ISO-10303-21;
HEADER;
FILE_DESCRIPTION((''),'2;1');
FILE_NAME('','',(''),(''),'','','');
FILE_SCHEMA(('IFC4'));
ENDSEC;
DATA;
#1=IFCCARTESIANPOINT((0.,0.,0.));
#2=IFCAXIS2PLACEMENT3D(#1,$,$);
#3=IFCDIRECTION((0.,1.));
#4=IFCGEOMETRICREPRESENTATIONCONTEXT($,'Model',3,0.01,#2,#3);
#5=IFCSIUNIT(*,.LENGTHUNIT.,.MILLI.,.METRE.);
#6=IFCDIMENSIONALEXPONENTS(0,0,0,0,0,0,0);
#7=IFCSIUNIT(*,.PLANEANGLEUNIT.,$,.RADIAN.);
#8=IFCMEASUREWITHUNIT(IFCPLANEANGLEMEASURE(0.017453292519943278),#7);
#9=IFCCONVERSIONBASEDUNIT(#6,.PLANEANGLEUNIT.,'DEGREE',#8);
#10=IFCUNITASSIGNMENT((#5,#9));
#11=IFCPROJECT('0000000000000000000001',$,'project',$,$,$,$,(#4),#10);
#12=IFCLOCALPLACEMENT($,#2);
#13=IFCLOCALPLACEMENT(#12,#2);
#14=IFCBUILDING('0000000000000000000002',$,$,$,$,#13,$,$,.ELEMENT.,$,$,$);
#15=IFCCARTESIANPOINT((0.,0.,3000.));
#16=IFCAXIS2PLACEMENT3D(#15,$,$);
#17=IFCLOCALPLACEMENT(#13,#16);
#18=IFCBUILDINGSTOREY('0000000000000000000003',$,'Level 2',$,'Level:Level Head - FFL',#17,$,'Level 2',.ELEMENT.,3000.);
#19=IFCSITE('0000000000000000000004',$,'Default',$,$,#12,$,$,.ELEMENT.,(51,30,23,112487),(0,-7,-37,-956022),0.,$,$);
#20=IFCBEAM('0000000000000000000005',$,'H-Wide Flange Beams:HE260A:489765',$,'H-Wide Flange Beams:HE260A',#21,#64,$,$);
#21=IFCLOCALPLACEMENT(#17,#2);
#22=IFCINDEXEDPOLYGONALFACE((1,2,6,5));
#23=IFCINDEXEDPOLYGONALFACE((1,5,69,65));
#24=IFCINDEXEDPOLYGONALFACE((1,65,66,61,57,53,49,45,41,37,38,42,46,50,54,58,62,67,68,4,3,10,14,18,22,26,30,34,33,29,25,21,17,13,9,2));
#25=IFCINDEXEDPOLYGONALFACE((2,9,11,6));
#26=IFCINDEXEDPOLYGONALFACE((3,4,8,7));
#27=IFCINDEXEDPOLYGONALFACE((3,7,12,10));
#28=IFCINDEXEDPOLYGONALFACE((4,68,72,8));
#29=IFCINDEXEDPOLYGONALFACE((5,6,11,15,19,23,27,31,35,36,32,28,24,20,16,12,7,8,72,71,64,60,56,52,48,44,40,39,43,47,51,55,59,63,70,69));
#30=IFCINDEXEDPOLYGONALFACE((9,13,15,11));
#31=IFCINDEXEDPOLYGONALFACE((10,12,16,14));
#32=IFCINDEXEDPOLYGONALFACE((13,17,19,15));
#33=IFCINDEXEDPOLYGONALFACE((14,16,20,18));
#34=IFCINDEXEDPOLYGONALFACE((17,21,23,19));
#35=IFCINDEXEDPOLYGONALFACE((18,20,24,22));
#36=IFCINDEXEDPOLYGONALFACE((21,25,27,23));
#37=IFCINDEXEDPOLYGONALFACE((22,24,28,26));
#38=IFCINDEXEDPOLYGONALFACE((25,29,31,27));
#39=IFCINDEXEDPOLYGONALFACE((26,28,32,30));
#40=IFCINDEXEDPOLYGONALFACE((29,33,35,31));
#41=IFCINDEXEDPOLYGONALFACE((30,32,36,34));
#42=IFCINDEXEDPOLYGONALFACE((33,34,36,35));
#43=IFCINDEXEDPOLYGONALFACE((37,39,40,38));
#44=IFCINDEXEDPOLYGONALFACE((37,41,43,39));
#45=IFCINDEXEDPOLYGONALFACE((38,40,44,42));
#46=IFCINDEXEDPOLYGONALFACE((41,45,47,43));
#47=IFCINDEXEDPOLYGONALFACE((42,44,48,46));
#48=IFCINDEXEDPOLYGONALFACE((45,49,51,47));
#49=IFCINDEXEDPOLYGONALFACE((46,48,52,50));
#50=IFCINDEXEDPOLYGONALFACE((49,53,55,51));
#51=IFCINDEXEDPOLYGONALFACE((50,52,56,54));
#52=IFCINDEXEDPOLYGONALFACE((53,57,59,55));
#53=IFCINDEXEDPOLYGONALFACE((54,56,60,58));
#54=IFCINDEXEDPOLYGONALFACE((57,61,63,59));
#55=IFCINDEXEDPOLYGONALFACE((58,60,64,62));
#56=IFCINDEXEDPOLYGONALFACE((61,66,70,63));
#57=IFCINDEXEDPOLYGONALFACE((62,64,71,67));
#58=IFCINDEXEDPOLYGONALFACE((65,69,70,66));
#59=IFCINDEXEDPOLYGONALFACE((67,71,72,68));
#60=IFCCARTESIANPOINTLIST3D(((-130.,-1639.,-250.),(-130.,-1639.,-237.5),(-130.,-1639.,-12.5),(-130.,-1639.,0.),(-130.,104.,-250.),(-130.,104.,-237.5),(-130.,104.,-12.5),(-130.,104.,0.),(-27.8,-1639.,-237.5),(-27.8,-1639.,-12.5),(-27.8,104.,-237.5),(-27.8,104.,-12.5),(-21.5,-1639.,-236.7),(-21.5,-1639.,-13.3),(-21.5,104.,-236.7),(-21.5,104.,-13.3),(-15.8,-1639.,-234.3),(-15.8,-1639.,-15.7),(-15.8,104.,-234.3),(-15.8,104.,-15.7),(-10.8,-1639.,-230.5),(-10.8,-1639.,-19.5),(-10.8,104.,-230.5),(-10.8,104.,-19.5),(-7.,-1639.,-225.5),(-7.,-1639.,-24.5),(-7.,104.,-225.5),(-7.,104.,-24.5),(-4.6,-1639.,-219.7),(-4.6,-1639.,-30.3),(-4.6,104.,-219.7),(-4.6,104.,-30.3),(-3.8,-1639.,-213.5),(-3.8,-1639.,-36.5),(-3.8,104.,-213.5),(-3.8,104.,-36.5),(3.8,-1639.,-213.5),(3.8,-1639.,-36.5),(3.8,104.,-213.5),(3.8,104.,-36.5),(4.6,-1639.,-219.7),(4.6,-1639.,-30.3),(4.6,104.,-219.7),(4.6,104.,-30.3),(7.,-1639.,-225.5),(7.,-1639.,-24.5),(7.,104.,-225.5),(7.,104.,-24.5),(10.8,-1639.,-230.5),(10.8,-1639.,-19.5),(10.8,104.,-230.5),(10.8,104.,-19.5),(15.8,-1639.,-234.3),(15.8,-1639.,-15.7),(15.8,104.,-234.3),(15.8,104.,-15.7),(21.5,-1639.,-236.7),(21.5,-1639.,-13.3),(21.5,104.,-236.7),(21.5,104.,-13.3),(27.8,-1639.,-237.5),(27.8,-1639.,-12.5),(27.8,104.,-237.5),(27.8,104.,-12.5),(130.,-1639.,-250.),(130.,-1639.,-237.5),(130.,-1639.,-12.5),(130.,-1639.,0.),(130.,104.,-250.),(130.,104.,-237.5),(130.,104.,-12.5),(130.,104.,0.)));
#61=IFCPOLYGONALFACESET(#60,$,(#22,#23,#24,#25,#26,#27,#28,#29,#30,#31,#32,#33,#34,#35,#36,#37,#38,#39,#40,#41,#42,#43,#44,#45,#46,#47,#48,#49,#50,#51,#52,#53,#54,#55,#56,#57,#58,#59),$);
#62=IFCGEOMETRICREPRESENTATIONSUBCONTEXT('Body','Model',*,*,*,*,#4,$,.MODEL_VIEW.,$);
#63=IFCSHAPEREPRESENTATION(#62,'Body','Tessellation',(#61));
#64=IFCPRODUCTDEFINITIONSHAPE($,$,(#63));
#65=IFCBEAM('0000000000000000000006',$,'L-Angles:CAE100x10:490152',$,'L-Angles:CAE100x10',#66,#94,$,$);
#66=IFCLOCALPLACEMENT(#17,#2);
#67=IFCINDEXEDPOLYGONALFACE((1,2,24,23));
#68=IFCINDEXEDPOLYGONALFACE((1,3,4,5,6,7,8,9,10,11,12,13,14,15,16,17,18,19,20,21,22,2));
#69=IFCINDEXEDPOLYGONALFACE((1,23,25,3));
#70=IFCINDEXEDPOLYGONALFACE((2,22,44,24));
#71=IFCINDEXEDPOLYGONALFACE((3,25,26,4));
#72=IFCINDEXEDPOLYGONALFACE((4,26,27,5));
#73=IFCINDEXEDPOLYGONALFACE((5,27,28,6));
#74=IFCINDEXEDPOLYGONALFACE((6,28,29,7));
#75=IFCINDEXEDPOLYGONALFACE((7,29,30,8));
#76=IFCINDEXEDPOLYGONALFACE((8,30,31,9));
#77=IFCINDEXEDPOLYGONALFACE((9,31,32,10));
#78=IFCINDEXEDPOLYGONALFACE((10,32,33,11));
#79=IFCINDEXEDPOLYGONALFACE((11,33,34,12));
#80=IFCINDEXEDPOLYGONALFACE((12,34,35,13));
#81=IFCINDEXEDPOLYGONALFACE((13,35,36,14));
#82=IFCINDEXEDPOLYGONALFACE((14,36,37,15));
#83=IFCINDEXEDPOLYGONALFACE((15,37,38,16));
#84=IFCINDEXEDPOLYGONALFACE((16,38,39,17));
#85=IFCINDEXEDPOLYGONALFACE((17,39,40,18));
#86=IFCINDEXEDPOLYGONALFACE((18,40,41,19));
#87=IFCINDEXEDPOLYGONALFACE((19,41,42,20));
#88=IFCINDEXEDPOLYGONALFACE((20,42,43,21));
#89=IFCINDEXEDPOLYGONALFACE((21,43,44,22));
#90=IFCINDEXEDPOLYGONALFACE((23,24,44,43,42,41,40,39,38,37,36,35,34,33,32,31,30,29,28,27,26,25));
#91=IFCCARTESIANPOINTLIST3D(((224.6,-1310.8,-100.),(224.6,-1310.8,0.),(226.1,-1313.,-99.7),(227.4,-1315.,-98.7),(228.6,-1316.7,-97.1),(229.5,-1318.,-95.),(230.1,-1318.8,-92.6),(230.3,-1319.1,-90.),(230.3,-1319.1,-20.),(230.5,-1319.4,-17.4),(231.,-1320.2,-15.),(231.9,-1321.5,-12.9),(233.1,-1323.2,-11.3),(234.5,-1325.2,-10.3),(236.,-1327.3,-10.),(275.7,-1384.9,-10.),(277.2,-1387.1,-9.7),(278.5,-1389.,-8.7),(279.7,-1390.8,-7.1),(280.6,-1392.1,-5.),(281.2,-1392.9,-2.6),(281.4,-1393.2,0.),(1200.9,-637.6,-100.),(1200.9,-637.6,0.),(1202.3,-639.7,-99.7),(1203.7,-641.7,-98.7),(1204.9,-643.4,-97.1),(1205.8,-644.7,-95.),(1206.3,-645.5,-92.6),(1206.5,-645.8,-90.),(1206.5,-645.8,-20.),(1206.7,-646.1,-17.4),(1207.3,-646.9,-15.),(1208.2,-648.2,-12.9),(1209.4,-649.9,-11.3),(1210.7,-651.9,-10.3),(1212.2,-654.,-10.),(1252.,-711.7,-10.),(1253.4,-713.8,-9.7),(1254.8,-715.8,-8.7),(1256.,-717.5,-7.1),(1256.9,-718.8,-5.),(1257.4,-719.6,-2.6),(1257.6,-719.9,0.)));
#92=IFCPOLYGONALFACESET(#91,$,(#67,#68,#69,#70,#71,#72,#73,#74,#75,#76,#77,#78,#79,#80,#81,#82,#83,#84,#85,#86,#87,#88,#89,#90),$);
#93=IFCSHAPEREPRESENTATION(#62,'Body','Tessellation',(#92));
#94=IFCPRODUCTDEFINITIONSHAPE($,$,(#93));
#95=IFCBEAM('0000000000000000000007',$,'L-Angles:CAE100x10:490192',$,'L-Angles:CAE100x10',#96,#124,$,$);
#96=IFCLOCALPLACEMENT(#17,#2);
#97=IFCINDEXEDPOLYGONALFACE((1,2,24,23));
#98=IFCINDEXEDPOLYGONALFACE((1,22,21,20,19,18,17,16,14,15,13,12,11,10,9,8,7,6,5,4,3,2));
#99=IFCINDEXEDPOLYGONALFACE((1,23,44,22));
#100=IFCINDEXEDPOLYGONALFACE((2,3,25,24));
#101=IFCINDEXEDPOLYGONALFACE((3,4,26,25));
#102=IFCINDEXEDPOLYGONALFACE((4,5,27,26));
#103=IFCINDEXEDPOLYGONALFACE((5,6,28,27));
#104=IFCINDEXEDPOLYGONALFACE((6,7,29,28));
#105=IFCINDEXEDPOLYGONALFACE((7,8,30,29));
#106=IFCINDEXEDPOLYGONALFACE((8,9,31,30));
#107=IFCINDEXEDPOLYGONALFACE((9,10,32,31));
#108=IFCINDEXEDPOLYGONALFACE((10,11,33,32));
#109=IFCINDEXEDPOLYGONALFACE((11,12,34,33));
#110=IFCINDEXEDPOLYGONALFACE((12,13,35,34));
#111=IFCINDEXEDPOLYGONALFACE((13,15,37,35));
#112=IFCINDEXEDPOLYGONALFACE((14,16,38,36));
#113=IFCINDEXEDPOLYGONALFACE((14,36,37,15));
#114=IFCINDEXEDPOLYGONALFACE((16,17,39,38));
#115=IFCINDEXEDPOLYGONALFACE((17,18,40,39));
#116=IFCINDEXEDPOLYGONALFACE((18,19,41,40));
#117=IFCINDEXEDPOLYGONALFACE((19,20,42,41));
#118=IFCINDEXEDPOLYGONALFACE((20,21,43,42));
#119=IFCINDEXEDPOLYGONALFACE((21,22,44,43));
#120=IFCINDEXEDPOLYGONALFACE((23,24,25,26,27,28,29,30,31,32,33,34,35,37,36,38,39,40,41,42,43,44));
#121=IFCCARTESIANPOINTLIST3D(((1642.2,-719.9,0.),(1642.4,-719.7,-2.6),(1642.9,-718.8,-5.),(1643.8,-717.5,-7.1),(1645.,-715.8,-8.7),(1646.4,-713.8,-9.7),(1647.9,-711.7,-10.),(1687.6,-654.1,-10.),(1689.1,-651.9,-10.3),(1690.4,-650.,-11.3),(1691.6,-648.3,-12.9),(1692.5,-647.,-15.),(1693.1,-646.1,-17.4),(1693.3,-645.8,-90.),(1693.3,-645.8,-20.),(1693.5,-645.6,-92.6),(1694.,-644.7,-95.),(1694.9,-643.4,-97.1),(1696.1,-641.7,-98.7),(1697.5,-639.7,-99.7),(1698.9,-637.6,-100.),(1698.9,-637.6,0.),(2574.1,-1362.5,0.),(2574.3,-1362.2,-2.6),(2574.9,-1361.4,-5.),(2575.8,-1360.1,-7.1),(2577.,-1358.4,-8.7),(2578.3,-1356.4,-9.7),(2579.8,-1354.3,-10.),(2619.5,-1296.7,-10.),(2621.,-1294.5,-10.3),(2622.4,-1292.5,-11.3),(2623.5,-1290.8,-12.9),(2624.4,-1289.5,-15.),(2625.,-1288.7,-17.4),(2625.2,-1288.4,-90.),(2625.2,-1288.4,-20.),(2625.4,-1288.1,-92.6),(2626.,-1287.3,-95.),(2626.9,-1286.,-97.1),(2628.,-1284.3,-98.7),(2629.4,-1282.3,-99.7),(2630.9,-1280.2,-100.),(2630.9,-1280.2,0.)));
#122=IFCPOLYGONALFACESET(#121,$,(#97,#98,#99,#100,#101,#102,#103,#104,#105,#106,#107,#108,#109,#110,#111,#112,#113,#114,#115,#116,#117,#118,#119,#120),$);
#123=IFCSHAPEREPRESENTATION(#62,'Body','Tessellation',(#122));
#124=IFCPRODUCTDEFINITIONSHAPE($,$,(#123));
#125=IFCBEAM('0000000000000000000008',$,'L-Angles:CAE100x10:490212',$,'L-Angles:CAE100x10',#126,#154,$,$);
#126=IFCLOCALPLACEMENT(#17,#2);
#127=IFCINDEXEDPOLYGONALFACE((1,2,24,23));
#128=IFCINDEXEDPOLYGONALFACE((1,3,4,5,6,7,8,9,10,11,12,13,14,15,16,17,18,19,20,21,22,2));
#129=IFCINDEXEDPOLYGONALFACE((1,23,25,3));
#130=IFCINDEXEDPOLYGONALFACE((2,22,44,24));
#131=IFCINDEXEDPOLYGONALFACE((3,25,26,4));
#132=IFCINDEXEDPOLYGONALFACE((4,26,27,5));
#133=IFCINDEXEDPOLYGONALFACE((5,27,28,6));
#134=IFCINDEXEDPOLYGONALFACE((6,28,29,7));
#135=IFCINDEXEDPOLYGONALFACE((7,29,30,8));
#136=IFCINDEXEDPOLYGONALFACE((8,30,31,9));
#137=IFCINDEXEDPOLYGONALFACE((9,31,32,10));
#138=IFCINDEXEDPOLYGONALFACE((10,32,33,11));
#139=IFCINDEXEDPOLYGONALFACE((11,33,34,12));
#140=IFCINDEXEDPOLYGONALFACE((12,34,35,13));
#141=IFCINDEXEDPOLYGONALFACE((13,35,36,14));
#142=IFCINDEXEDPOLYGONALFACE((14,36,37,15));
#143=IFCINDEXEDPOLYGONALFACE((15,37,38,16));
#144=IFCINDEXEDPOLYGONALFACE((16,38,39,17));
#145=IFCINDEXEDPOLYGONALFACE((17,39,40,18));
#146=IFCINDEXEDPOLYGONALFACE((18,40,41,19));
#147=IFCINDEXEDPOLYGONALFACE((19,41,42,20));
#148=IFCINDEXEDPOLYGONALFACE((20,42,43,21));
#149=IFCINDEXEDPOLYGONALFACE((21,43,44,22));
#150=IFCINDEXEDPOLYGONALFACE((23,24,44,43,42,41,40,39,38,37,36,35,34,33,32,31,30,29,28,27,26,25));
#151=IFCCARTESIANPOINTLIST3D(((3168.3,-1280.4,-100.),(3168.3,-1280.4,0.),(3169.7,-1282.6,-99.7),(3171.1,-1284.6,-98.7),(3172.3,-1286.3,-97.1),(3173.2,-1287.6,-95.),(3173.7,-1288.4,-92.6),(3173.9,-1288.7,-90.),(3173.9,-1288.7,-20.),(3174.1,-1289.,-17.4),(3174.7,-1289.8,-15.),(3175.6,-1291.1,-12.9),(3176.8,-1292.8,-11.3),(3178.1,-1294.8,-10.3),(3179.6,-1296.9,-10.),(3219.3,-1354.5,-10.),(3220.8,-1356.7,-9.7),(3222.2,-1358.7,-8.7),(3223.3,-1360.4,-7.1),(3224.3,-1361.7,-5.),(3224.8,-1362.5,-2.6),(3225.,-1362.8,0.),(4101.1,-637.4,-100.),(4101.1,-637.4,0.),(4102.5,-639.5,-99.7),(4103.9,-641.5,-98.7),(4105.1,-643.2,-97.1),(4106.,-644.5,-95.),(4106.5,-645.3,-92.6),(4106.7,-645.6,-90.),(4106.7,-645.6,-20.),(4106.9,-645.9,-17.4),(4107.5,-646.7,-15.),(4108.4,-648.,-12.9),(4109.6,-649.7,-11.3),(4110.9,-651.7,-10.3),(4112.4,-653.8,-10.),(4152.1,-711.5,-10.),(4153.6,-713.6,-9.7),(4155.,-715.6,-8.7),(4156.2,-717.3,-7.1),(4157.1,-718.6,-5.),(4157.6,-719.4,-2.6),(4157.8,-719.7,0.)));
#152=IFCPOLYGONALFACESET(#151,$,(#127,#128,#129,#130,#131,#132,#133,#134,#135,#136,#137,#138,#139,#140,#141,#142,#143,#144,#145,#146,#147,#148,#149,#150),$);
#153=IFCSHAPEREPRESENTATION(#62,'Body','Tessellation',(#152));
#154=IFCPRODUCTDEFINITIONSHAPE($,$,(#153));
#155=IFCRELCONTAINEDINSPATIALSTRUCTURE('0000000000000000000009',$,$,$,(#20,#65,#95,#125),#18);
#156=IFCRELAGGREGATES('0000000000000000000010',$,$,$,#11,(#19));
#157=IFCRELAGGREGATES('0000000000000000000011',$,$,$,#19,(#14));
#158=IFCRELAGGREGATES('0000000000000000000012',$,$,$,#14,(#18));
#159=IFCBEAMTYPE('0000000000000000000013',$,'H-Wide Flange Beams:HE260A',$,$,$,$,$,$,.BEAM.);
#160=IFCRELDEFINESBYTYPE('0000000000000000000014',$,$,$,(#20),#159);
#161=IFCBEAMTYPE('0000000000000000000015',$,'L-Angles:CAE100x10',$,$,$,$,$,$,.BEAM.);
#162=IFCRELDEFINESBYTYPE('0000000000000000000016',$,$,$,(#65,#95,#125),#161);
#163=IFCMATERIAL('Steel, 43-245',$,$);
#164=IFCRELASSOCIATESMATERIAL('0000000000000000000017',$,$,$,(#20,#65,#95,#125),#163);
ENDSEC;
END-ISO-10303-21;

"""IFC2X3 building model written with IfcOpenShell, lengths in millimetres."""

from ifc_helpers import new_model, entity, si_unit, converted_unit, direction, frame, frame_2d, origin, place, context, subcontext, project, spatial, polyline, circle_curve, parameter, trimmed, segment, composite_curve, i_section, outline, extrude, material, type_object, element, save


model = new_model("IFC2X3")

# Units and contexts
model_context = context("Model", 3, precision=0.01, world=origin(), true_north=direction((0.0, 1.0)))
body_context = subcontext(model_context, "Body", "Model", "MODEL_VIEW")
ifc_project = project(units=[si_unit("LENGTHUNIT", "METRE", prefix="MILLI"), converted_unit("PLANEANGLEUNIT", "DEGREE", entity("IfcPlaneAngleMeasure", 0.017453292519943278), si_unit("PLANEANGLEUNIT", "RADIAN"), dimensions=[0, 0, 0, 0, 0, 0, 0])], contexts=[model_context])

# Site, building, storey
site_placement = place(None, origin())
site = spatial("IfcSite", under=ifc_project, at=site_placement, Name="Default", CompositionType="ELEMENT", RefLatitude=(51, 30, 23, 112487), RefLongitude=(0, -7, -37, -956022), RefElevation=0.0)
building_placement = place(site_placement, origin())
building = spatial("IfcBuilding", under=site, at=building_placement, CompositionType="ELEMENT")
storey_placement = place(building_placement, frame((0.0, 0.0, 3000.0)))
storey = spatial("IfcBuildingStorey", under=building, at=storey_placement, Name="Level 2", ObjectType="Level:Level Head - FFL", LongName="Level 2", CompositionType="ELEMENT", Elevation=3000.0)

# Beams
ifc_material = material(Name="Steel, 43-245")
beam_type_1 = type_object("IfcBeamType", Name="H-Wide Flange Beams:HE260A", PredefinedType="BEAM")
beam_1_placement = place(storey_placement, frame((0.0, -1500.0, 0.0), z_axis=(0.0, 0.0, 1.0), x_axis=(0.0, 1.0, 0.0)))
element("IfcBeam", 1, at=beam_1_placement, inside=storey, type_object=beam_type_1, material=ifc_material, Name="H-Wide Flange Beams:HE260A:489765", ObjectType="H-Wide Flange Beams:HE260A", context=body_context, shape_type="SweptSolid", body=[
    extrude(i_section(OverallWidth=260.0, OverallDepth=250.0, WebThickness=7.5, FlangeThickness=12.5, FilletRadius=24.0, at=frame_2d((0.0, 0.0), x_axis=(0.0, 1.0))), frame((-139.0, 0.0, -125.0), z_axis=(1.0, 0.0, 0.0), x_axis=(0.0, 0.0, -1.0)), (0.0, 0.0, 1.0), 1743.0),
])
beam_type_2 = type_object("IfcBeamType", Name="L-Angles:CAE100x10", PredefinedType="BEAM")
beam_2_placement = place(storey_placement, frame((0.0, -1500.0, 0.0), z_axis=(0.0, 0.0, 1.0), x_axis=(0.823213, 0.567733, 0.0)))
element("IfcBeam", 2, at=beam_2_placement, inside=storey, type_object=beam_type_2, material=ifc_material, Name="L-Angles:CAE100x10:490152", ObjectType="L-Angles:CAE100x10", context=body_context, shape_type="SweptSolid", body=[
    extrude(outline(composite_curve([segment(polyline([(-67.1, -32.9), (32.9, -32.9)]), True, "CONTINUOUS"), segment(polyline([(32.9, -32.9), (32.9, 67.1)]), True, "CONTINUOUS"), segment(trimmed(circle_curve(frame_2d((32.9, 57.1), x_axis=(0.0, 1.0)), 10.0), [parameter(0.0)], [parameter(90.0)], True, "PARAMETER"), True, "CONTINUOUS"), segment(polyline([(22.9, 57.1), (22.9, -12.9)]), True, "CONTINUOUS"), segment(trimmed(circle_curve(frame_2d((12.9, -12.9), x_axis=(1.0, 0.0)), 10.0), [parameter(270.0)], [parameter(0.0)], True, "PARAMETER"), False, "CONTINUOUS"), segment(polyline([(12.9, -22.9), (-57.1, -22.9)]), True, "CONTINUOUS"), segment(trimmed(circle_curve(frame_2d((-57.1, -32.9), x_axis=(0.0, 1.0)), 10.0), [parameter(0.0)], [parameter(90.0)], True, "PARAMETER"), True, "CONTINUOUS")], self_intersect=False)), frame((292.3, -4.7, -32.9), z_axis=(1.0, 0.0, 0.0), x_axis=(0.0, 0.0, 1.0)), (0.0, 0.0, 1.0), 1185.9),
])
beam_3_placement = place(storey_placement, frame((1449.7, -500.0, 0.0), z_axis=(0.0, 0.0, 1.0), x_axis=(0.823272, -0.567647, 0.0)))
element("IfcBeam", 3, at=beam_3_placement, inside=storey, type_object=beam_type_2, material=ifc_material, Name="L-Angles:CAE100x10:490192", ObjectType="L-Angles:CAE100x10", context=body_context, shape_type="SweptSolid", body=[
    extrude(outline(composite_curve([segment(polyline([(-67.1, -32.9), (32.9, -32.9)]), True, "CONTINUOUS"), segment(polyline([(32.9, -32.9), (32.9, 67.1)]), True, "CONTINUOUS"), segment(trimmed(circle_curve(frame_2d((32.9, 57.1), x_axis=(0.0, 1.0)), 10.0), [parameter(0.0)], [parameter(90.0)], True, "PARAMETER"), True, "CONTINUOUS"), segment(polyline([(22.9, 57.1), (22.9, -12.9)]), True, "CONTINUOUS"), segment(trimmed(circle_curve(frame_2d((12.9, -12.9), x_axis=(1.0, 0.0)), 10.0), [parameter(270.0)], [parameter(0.0)], True, "PARAMETER"), False, "CONTINUOUS"), segment(polyline([(12.9, -22.9), (-57.1, -22.9)]), True, "CONTINUOUS"), segment(trimmed(circle_curve(frame_2d((-57.1, -32.9), x_axis=(0.0, 1.0)), 10.0), [parameter(0.0)], [parameter(90.0)], True, "PARAMETER"), True, "CONTINUOUS")], self_intersect=False)), frame((283.3, -4.7, -32.9), z_axis=(1.0, 0.0, 0.0), x_axis=(0.0, 0.0, 1.0)), (0.0, 0.0, 1.0), 1132.0),
])
beam_4_placement = place(storey_placement, frame((2899.5, -1500.0, 0.0), z_axis=(0.0, 0.0, 1.0), x_axis=(0.823312, 0.567589, 0.0)))
element("IfcBeam", 4, at=beam_4_placement, inside=storey, type_object=beam_type_2, material=ifc_material, Name="L-Angles:CAE100x10:490212", ObjectType="L-Angles:CAE100x10", context=body_context, shape_type="SweptSolid", body=[
    extrude(outline(composite_curve([segment(polyline([(-67.1, -32.9), (32.9, -32.9)]), True, "CONTINUOUS"), segment(polyline([(32.9, -32.9), (32.9, 67.1)]), True, "CONTINUOUS"), segment(trimmed(circle_curve(frame_2d((32.9, 57.1), x_axis=(0.0, 1.0)), 10.0), [parameter(0.0)], [parameter(90.0)], True, "PARAMETER"), True, "CONTINUOUS"), segment(polyline([(22.9, 57.1), (22.9, -12.9)]), True, "CONTINUOUS"), segment(trimmed(circle_curve(frame_2d((12.9, -12.9), x_axis=(1.0, 0.0)), 10.0), [parameter(270.0)], [parameter(0.0)], True, "PARAMETER"), False, "CONTINUOUS"), segment(polyline([(12.9, -22.9), (-57.1, -22.9)]), True, "CONTINUOUS"), segment(trimmed(circle_curve(frame_2d((-57.1, -32.9), x_axis=(0.0, 1.0)), 10.0), [parameter(0.0)], [parameter(90.0)], True, "PARAMETER"), True, "CONTINUOUS")], self_intersect=False)), frame((345.9, -4.7, -32.9), z_axis=(1.0, 0.0, 0.0), x_axis=(0.0, 0.0, 1.0)), (0.0, 0.0, 1.0), 1133.0),
])

save(model, "model.ifc")
